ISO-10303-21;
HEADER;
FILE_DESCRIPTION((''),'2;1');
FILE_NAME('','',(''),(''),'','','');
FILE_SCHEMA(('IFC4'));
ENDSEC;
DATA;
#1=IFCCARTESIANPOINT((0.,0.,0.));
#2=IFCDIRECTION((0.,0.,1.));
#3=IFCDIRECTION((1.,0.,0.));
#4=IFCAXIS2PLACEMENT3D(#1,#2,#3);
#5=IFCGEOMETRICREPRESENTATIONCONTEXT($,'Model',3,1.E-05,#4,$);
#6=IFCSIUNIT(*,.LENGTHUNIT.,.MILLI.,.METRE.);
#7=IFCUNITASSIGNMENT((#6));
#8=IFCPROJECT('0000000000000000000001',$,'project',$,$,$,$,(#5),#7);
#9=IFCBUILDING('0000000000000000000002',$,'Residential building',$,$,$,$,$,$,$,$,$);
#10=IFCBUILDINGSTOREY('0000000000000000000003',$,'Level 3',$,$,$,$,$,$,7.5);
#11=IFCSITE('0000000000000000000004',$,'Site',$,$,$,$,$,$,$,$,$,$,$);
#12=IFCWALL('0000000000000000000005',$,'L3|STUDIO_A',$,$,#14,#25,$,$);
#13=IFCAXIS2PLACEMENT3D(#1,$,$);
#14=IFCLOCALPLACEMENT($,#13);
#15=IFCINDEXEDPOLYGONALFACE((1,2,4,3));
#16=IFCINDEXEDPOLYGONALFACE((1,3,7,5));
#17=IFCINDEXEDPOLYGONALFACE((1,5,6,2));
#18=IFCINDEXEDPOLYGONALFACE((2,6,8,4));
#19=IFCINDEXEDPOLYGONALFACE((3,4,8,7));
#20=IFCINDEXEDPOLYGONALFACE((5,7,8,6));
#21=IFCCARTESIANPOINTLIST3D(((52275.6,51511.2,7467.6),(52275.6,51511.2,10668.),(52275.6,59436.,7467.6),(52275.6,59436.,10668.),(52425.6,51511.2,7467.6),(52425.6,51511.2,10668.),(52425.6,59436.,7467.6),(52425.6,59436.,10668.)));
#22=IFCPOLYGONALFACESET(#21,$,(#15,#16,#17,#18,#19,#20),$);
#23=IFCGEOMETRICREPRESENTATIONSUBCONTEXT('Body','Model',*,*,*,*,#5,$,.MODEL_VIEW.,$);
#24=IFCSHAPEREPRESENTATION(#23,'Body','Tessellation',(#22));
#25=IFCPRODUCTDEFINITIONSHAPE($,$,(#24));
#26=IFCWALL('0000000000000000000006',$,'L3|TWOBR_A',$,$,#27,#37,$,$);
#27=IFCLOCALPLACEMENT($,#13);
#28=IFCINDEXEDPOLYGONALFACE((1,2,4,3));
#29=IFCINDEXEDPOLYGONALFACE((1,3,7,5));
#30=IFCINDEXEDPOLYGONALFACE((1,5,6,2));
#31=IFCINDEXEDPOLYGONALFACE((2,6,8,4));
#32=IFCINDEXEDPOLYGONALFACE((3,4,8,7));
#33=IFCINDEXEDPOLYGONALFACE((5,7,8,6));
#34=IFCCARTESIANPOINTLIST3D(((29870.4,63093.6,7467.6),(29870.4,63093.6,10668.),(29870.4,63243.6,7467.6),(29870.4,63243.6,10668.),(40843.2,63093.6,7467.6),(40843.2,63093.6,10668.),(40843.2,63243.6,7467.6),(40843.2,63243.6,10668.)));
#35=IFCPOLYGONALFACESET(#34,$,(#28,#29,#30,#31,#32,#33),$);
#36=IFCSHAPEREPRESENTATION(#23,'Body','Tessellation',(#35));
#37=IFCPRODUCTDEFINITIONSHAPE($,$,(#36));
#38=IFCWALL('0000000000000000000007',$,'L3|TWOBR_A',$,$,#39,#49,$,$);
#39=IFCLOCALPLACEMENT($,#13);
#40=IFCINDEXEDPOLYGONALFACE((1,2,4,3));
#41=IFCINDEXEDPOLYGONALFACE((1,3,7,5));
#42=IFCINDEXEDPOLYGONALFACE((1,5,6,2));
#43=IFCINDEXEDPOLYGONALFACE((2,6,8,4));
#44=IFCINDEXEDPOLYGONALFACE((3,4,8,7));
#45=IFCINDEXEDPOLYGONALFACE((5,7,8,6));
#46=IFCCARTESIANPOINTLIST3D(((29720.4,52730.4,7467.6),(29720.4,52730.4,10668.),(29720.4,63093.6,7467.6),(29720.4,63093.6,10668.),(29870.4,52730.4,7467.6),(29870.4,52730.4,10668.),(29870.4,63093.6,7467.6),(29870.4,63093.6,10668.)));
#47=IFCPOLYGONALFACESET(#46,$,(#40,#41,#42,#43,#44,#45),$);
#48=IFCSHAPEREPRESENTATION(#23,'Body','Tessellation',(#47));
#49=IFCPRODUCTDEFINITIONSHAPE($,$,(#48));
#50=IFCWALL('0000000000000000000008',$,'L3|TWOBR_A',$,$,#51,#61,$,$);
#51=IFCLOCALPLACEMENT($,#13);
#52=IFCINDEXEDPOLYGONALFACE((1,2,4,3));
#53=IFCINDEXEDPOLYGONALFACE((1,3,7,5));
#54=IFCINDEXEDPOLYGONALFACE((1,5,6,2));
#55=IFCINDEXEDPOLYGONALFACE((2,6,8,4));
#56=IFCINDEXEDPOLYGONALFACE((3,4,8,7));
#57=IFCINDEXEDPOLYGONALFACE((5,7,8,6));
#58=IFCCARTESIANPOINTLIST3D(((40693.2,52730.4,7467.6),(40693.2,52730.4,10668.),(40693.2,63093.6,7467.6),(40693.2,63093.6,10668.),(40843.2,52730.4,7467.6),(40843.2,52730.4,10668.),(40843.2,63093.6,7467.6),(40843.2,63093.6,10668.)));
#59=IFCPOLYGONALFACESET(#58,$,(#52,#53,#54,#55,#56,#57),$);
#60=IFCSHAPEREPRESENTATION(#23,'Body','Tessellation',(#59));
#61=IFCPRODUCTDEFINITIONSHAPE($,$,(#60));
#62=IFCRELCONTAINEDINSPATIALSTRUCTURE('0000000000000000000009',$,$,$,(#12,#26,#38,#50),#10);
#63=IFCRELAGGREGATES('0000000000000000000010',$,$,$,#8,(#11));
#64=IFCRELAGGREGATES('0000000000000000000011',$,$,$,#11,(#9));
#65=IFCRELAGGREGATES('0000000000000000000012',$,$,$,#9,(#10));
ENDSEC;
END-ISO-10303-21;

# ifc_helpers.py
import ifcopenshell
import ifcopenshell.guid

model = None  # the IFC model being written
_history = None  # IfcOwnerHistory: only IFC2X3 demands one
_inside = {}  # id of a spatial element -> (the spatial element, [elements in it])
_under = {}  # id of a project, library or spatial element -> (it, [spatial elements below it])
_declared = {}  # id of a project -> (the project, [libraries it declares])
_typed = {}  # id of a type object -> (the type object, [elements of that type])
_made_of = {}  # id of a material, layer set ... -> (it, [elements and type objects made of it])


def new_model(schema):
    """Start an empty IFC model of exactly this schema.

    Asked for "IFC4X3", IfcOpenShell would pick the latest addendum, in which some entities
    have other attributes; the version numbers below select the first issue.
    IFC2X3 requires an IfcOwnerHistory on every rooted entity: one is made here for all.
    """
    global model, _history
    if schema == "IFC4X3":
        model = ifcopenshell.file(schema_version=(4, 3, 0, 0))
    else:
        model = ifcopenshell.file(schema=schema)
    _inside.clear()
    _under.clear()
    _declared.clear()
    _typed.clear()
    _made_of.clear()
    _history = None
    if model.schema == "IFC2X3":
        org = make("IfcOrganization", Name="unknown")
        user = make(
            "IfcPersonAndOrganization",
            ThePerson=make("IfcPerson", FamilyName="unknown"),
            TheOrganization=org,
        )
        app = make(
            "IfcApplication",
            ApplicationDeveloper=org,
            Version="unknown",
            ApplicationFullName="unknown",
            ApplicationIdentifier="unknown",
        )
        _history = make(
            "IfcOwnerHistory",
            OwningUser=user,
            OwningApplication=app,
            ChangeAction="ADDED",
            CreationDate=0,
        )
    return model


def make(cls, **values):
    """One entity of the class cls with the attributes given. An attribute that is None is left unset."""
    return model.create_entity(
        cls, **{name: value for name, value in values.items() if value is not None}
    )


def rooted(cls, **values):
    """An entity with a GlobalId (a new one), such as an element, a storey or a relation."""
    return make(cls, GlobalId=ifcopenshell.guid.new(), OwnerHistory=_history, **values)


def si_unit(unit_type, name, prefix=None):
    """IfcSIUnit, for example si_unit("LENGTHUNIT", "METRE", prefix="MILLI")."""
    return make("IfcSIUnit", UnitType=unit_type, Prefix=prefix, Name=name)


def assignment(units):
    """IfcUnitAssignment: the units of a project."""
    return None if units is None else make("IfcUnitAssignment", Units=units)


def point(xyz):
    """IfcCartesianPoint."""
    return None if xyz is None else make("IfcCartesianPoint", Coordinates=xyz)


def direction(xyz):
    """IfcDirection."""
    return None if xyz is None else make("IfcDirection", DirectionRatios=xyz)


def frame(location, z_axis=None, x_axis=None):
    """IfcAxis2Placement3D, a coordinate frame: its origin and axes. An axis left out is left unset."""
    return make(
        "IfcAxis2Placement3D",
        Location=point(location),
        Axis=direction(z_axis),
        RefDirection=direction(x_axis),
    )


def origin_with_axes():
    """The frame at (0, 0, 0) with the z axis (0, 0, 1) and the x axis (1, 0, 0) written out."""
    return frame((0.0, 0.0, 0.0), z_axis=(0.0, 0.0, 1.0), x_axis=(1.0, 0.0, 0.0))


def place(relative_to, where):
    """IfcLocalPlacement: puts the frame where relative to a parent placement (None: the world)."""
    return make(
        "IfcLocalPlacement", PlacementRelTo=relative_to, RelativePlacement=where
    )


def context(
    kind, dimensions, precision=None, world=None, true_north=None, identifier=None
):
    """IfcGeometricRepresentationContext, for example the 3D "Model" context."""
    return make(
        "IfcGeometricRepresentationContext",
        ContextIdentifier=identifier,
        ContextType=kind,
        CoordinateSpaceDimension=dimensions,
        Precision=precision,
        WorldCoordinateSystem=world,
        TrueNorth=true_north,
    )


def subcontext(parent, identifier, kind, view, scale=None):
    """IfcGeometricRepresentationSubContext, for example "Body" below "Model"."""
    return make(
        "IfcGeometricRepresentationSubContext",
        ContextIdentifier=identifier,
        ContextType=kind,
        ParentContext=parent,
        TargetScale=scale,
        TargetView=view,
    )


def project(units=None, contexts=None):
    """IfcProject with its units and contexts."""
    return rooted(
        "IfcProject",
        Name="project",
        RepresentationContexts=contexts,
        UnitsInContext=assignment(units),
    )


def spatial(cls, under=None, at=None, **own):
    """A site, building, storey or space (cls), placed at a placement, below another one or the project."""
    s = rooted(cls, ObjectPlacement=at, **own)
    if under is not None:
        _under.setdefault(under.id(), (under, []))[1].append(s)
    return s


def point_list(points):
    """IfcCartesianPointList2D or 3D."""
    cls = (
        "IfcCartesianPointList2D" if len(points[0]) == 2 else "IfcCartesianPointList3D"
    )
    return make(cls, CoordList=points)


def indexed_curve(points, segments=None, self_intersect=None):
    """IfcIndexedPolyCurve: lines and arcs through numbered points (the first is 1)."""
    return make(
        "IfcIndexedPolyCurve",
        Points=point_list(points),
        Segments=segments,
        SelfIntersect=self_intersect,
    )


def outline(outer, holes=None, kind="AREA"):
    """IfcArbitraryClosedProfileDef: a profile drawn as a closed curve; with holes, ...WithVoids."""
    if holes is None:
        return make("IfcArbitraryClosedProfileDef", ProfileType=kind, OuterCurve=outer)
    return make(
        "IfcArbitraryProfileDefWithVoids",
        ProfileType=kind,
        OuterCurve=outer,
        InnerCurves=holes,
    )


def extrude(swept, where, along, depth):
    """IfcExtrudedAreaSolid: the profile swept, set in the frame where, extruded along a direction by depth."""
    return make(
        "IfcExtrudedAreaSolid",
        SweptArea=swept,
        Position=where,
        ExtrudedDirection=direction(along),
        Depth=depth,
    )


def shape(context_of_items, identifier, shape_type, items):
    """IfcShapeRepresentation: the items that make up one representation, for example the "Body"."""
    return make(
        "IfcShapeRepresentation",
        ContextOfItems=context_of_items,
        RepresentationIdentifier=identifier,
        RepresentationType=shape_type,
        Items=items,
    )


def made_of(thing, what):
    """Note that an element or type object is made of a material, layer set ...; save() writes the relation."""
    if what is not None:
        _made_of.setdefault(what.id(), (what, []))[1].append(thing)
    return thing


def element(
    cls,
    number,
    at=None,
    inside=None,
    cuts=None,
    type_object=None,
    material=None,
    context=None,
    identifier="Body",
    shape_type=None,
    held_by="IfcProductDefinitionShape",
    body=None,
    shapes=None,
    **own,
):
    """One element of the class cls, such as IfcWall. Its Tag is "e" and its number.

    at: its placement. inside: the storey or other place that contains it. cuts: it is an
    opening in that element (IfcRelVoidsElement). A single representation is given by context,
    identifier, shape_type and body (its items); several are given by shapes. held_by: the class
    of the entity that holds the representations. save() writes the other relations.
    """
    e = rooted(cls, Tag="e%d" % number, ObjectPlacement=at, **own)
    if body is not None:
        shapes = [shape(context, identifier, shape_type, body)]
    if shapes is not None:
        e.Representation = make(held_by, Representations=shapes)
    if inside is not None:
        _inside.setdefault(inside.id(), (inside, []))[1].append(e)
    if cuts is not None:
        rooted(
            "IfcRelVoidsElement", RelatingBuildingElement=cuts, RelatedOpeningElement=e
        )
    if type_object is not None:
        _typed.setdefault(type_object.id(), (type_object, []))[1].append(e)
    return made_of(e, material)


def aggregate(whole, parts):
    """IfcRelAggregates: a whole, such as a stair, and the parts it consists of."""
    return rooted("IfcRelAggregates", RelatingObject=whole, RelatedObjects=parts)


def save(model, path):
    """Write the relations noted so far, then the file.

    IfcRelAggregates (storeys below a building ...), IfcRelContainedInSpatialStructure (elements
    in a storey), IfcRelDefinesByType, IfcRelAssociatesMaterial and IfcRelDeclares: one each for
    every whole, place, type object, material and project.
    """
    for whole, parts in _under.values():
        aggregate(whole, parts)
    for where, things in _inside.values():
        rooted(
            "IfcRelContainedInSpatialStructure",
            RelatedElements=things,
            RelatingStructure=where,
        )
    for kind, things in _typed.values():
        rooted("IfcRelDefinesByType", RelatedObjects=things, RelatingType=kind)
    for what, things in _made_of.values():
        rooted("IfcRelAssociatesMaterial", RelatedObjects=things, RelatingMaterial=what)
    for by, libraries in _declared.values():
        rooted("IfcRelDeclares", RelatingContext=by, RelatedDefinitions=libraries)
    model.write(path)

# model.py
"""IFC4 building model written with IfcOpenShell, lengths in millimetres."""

from ifc_helpers import new_model, si_unit, frame, origin_with_axes, place, context, subcontext, project, spatial, indexed_curve, outline, extrude, element, save


model = new_model("IFC4")

# Units and contexts
model_context = context("Model", 3, precision=1e-05, world=origin_with_axes())
body_context = subcontext(model_context, "Body", "Model", "MODEL_VIEW")
ifc_project = project(units=[si_unit("LENGTHUNIT", "METRE", prefix="MILLI")], contexts=[model_context])

# Site, building, storey
site = spatial("IfcSite", under=ifc_project, Name="Site")
building = spatial("IfcBuilding", under=site, Name="Residential building")
storey = spatial("IfcBuildingStorey", under=building, Name="Level 3", Elevation=7.5)

# Walls
for number, where, z_axis, x_axis, name in (
    (1, (52425.6, 51511.2, 7467.6), (0.0, 0.0, 1.0), (0.0, 1.0, 0.0), "L3|STUDIO_A"),
):
    element("IfcWall", number, at=place(None, frame(where, z_axis=z_axis, x_axis=x_axis)), inside=storey, Name=name, context=body_context, shape_type="SweptSolid", body=[
        extrude(outline(indexed_curve([(0.0, 0.0), (0.0, 150.0), (7924.8, 150.0), (7924.8, 0.0), (0.0, 0.0)], self_intersect=False)), origin_with_axes(), (0.0, 0.0, 1.0), 3200.4),
    ])
for number, where, z_axis, x_axis, name in (
    (2, (29870.4, 63093.6, 7467.6), (0.0, 0.0, 1.0), (1.0, 0.0, 0.0), "L3|TWOBR_A"),
):
    element("IfcWall", number, at=place(None, frame(where, z_axis=z_axis, x_axis=x_axis)), inside=storey, Name=name, context=body_context, shape_type="SweptSolid", body=[
        extrude(outline(indexed_curve([(0.0, 0.0), (0.0, 150.0), (10972.8, 150.0), (10972.8, 0.0), (0.0, 0.0)], self_intersect=False)), origin_with_axes(), (0.0, 0.0, 1.0), 3200.4),
    ])
for number, where, z_axis, x_axis, name in (
    (3, (29870.4, 52730.4, 7467.6), (0.0, 0.0, 1.0), (0.0, 1.0, 0.0), "L3|TWOBR_A"),
    (4, (40843.2, 52730.4, 7467.6), (0.0, 0.0, 1.0), (0.0, 1.0, 0.0), "L3|TWOBR_A"),
):
    element("IfcWall", number, at=place(None, frame(where, z_axis=z_axis, x_axis=x_axis)), inside=storey, Name=name, context=body_context, shape_type="SweptSolid", body=[
        extrude(outline(indexed_curve([(0.0, 0.0), (0.0, 150.0), (10363.2, 150.0), (10363.2, 0.0), (0.0, 0.0)], self_intersect=False)), origin_with_axes(), (0.0, 0.0, 1.0), 3200.4),
    ])

save(model, "model.ifc")
